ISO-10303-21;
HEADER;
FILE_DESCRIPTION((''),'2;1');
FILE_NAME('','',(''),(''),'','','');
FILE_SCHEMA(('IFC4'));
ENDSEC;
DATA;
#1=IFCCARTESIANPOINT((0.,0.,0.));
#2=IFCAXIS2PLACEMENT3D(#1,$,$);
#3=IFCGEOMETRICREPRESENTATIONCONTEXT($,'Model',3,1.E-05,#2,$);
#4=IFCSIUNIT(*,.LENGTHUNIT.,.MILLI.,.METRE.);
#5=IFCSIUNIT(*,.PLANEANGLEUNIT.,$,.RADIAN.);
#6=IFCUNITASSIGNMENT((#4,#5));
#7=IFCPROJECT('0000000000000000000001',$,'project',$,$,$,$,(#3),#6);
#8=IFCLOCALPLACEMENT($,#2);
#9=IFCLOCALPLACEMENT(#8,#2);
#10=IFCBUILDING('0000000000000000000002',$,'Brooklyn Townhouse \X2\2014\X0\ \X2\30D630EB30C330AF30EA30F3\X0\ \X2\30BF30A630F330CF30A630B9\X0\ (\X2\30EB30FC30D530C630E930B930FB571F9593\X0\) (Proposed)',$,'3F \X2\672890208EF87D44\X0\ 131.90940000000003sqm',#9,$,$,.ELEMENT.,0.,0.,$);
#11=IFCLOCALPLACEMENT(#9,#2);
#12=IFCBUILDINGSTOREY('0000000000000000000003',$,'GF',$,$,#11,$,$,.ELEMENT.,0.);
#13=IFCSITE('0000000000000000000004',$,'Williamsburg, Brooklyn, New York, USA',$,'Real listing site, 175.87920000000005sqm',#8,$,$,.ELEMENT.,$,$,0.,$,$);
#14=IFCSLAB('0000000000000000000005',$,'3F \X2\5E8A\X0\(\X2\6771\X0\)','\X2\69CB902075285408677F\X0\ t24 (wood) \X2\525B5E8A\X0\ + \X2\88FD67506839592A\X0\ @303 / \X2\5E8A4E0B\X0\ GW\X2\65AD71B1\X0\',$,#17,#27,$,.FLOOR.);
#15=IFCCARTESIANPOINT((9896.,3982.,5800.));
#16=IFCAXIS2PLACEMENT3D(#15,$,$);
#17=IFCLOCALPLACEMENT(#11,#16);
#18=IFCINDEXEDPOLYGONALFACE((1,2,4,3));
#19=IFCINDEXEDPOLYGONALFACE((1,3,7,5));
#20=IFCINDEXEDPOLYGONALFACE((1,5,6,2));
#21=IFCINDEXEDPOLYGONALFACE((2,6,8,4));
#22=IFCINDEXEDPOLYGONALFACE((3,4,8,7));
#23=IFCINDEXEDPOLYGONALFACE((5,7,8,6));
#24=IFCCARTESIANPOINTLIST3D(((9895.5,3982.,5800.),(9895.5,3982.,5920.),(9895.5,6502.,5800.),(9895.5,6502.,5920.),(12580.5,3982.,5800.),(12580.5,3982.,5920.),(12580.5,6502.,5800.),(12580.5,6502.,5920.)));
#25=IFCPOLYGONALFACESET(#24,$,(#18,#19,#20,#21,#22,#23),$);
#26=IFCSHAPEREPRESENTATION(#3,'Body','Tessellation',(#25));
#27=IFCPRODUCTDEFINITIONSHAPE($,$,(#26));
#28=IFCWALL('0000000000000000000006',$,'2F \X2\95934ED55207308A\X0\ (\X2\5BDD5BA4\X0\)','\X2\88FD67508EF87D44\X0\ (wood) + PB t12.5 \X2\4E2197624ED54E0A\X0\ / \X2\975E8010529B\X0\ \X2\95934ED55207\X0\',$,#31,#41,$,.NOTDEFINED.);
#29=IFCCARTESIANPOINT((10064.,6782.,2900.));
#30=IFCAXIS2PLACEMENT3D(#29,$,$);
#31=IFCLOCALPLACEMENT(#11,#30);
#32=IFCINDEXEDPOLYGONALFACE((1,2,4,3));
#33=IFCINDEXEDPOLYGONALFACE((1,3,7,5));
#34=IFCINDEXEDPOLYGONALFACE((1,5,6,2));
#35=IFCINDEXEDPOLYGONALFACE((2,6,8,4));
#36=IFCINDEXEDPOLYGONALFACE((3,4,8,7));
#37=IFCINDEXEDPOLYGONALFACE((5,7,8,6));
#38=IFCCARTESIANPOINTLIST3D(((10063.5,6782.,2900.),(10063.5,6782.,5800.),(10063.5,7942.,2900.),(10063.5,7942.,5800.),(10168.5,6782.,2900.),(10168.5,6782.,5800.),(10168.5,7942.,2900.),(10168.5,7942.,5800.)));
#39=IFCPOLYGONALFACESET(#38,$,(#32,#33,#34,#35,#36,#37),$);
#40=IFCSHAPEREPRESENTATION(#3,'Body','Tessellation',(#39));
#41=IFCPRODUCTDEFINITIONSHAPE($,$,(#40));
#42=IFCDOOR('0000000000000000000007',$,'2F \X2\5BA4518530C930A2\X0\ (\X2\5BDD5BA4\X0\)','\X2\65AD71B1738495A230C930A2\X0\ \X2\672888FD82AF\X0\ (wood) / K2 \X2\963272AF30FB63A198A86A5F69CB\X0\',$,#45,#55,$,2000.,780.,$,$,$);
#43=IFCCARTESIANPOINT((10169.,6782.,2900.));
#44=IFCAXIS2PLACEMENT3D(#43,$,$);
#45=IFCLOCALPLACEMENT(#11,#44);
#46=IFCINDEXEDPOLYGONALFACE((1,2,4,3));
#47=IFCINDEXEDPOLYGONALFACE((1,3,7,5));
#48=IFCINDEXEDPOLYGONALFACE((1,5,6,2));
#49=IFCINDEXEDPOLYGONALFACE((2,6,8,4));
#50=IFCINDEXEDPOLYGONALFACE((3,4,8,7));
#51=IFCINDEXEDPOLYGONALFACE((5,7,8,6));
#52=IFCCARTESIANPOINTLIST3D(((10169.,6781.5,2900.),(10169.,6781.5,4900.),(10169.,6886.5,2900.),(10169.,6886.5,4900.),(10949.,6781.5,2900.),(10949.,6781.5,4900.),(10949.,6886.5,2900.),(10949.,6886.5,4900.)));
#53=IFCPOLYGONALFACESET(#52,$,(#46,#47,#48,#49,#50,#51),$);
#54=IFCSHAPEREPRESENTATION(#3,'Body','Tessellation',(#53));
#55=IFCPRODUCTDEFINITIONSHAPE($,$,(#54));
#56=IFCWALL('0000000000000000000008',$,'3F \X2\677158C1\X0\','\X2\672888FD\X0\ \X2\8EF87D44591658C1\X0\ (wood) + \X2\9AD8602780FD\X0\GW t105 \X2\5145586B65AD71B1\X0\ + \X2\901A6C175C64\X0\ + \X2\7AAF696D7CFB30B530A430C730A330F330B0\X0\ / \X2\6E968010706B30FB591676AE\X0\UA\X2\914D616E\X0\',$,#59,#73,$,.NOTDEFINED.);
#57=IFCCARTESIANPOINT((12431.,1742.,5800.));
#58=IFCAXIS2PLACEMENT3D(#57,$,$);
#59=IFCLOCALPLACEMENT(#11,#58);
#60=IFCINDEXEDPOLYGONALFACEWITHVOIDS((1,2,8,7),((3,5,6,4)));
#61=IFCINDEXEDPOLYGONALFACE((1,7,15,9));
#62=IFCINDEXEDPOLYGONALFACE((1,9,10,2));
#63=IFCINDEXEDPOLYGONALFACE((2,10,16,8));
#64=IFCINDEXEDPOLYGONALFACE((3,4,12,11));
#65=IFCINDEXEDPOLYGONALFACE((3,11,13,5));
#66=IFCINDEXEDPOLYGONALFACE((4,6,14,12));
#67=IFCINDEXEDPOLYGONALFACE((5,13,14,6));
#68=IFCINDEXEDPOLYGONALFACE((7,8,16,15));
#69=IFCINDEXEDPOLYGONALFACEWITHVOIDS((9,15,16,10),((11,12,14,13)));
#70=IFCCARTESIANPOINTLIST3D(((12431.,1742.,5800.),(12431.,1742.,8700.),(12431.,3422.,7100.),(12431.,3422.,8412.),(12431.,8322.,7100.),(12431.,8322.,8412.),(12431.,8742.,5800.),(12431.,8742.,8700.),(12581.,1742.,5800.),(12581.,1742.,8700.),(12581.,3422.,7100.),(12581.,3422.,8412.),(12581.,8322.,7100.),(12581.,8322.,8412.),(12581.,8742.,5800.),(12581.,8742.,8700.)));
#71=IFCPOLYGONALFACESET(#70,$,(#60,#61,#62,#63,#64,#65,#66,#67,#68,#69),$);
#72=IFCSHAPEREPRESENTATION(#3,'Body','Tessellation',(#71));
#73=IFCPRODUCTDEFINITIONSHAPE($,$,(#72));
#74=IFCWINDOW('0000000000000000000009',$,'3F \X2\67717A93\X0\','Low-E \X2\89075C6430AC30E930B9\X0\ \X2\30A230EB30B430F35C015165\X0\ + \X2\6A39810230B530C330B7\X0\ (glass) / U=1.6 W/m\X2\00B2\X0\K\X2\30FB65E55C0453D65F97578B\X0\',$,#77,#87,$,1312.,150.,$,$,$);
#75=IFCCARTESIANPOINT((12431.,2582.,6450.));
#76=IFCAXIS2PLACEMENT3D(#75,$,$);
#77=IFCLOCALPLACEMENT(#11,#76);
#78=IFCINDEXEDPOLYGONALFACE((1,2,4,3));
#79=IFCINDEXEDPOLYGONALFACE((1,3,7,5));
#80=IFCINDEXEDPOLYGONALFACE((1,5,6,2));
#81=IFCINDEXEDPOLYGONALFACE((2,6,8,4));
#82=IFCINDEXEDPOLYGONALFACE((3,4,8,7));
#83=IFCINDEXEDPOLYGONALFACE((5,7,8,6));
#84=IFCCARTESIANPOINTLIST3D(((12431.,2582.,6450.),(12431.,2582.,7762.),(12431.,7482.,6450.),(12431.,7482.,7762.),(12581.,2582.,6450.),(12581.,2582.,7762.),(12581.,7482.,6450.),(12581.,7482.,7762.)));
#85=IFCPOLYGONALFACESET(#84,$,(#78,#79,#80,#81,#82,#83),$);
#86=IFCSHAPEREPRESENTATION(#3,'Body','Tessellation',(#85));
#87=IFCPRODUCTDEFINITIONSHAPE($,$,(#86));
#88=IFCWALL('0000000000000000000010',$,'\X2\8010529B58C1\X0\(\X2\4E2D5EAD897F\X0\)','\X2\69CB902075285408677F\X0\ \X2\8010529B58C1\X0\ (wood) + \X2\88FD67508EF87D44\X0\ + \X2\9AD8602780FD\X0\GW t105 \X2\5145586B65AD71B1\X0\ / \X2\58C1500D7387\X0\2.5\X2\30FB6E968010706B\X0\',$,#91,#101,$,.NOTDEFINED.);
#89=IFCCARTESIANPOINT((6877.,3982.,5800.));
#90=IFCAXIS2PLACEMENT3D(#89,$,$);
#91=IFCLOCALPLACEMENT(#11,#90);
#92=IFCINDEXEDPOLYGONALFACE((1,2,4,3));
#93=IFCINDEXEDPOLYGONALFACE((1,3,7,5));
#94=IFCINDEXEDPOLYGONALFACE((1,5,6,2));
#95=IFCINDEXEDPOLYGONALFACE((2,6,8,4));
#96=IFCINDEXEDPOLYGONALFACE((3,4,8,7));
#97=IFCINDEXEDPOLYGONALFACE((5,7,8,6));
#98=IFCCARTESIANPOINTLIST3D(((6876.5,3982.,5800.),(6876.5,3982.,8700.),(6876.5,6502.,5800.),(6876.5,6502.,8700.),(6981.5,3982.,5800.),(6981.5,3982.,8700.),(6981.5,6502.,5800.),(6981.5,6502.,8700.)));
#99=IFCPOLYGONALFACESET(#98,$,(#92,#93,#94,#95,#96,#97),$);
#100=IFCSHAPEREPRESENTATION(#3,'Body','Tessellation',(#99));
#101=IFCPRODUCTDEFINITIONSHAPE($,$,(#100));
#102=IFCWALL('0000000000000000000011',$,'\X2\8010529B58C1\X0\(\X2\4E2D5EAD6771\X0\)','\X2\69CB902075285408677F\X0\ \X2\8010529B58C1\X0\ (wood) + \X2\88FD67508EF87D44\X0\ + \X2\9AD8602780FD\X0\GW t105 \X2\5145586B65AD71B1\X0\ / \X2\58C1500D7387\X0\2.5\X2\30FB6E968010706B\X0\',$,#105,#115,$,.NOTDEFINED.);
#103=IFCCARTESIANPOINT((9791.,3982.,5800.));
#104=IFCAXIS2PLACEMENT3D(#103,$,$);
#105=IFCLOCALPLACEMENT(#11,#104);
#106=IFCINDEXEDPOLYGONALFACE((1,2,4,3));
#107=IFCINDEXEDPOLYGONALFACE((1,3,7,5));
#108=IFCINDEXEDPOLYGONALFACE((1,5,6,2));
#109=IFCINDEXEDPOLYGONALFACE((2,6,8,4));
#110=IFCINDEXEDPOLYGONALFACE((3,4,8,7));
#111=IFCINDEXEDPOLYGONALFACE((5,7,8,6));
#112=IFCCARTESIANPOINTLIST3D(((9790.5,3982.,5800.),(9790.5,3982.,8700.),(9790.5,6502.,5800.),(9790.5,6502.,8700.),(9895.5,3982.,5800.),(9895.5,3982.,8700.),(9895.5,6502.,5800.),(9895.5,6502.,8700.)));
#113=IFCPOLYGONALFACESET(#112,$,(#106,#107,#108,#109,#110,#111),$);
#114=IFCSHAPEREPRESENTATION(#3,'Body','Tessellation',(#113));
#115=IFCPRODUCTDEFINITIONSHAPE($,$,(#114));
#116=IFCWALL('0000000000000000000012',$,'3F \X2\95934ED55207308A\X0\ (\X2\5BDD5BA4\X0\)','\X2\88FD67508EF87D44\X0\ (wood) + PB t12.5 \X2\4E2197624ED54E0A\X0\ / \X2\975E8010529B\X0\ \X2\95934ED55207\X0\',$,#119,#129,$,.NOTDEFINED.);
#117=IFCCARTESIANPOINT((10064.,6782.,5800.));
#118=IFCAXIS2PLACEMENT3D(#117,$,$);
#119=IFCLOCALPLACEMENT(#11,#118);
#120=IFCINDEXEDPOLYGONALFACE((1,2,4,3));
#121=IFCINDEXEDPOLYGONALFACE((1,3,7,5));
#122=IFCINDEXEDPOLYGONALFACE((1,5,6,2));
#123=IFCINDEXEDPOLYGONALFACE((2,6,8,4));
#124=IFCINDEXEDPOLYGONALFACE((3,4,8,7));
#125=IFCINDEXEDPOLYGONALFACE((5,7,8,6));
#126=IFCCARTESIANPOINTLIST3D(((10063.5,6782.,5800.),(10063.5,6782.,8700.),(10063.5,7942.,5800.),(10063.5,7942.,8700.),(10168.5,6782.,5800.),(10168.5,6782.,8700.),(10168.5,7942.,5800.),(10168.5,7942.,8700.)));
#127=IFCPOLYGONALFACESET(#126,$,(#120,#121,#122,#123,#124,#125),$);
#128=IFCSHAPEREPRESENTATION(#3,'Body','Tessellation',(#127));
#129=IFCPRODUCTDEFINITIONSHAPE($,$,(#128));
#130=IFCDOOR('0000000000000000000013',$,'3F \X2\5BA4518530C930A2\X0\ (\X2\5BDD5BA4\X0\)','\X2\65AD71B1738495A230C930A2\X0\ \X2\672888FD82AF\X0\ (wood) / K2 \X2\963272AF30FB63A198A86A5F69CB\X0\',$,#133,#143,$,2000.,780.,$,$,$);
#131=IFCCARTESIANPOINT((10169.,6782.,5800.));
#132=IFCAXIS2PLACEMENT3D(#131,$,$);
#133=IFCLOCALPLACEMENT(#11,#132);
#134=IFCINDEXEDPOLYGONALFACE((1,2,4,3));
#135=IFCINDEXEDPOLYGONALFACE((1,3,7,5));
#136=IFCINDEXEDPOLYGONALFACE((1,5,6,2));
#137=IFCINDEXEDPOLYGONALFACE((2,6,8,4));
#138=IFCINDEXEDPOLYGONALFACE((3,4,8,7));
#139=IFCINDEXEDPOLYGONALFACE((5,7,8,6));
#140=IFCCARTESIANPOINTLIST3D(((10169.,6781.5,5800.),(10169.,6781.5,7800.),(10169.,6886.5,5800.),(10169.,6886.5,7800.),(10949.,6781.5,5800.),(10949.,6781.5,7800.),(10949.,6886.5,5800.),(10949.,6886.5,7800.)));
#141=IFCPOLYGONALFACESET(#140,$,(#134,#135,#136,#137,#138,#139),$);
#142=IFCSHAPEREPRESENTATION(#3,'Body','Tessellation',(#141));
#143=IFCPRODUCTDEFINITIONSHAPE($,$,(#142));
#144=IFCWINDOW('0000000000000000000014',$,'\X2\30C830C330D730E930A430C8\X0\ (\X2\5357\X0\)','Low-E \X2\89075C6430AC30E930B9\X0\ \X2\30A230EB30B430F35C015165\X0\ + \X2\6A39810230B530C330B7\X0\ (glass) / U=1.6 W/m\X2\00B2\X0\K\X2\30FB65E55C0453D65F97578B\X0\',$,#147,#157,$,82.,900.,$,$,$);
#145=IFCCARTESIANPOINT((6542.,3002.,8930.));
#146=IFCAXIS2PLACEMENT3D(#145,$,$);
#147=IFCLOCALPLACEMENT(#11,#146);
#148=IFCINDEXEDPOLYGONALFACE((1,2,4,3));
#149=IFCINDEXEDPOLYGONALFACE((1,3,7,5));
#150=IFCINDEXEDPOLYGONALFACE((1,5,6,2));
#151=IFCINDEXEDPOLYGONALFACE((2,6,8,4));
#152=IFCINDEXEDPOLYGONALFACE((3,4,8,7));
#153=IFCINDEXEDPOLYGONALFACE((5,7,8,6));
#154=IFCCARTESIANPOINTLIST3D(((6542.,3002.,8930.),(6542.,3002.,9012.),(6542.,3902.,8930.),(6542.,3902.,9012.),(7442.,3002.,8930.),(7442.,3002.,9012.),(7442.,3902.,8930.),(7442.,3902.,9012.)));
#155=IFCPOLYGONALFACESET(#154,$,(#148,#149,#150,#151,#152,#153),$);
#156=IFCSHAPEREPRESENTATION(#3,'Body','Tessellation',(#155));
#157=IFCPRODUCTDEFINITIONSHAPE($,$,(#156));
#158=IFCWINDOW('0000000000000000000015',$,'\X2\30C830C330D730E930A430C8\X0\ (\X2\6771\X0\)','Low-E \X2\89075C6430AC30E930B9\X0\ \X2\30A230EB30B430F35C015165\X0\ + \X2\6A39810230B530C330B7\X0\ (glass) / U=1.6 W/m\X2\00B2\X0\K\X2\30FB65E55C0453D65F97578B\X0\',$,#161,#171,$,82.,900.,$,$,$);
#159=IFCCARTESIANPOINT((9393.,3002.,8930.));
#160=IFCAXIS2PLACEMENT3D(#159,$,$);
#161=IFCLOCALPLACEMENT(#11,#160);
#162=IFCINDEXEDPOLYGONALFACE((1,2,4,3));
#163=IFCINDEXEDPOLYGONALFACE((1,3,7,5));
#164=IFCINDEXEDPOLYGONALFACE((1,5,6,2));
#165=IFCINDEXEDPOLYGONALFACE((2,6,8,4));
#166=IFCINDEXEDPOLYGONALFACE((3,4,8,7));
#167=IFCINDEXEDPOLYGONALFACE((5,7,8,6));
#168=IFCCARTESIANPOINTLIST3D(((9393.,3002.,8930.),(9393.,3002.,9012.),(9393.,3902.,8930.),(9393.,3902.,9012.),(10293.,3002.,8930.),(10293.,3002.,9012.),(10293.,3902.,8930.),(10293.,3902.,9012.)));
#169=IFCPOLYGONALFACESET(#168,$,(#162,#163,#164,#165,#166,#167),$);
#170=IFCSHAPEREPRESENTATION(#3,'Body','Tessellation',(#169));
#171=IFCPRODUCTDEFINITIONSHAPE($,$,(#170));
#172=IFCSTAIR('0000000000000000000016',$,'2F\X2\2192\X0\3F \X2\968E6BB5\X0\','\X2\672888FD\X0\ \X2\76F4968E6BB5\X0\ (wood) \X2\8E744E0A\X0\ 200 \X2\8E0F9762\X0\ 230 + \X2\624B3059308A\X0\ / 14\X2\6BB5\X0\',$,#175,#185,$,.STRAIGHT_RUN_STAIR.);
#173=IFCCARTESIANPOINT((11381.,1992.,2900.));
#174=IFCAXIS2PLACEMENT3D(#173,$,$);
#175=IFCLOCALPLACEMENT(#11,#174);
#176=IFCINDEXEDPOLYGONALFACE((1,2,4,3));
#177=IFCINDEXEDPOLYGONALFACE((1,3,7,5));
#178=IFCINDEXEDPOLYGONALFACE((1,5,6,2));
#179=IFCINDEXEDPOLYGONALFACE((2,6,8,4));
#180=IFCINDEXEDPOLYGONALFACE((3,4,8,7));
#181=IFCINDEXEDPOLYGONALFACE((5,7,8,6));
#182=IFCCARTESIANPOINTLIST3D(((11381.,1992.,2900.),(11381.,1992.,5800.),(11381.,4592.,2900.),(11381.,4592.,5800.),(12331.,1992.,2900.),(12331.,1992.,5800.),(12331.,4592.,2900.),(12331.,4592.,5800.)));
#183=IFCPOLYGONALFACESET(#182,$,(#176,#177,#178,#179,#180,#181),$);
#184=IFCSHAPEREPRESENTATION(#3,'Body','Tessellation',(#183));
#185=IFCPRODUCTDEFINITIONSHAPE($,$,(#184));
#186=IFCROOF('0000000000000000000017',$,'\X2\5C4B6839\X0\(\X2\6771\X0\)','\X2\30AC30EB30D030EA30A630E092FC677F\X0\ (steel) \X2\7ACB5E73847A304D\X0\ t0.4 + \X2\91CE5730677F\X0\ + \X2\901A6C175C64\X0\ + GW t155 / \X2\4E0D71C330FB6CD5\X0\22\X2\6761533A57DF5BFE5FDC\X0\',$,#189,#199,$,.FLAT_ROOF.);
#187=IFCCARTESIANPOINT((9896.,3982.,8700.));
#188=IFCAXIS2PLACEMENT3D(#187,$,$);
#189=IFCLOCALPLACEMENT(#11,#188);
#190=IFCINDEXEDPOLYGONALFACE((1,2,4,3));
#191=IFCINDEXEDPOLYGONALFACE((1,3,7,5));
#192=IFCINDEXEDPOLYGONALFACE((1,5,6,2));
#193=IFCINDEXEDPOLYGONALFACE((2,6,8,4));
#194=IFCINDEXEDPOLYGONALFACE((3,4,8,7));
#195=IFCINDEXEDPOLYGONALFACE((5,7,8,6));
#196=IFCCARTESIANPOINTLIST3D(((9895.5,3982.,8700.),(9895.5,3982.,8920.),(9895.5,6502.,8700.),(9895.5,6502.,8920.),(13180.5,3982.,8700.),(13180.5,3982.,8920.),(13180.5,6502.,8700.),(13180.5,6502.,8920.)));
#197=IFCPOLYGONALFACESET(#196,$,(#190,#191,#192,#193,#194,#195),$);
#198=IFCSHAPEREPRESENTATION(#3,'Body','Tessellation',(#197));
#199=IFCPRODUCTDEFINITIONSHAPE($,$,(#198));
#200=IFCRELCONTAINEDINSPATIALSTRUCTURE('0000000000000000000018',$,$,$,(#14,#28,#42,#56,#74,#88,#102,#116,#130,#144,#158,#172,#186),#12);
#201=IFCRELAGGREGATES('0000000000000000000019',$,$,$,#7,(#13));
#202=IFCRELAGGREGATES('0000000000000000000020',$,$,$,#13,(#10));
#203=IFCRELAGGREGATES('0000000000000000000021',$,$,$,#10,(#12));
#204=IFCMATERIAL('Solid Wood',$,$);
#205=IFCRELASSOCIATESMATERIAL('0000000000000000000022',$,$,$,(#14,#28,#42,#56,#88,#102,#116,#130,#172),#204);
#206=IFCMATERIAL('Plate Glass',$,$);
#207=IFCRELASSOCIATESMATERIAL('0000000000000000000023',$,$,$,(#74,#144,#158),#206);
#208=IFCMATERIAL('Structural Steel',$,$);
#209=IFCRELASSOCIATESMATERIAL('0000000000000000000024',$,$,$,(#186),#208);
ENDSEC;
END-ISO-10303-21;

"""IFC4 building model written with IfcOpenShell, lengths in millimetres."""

from ifc_helpers import new_model, si_unit, frame, frame_2d, origin, place, context, project, spatial, rectangle, extrude, material, element, fill, save


model = new_model("IFC4")

# Units and contexts
model_context = context("Model", 3, precision=1e-05, world=origin())
ifc_project = project(units=[si_unit("LENGTHUNIT", "METRE", prefix="MILLI"), si_unit("PLANEANGLEUNIT", "RADIAN")], contexts=[model_context])

# Site, building, storey
site_placement = place(None, origin())
site = spatial("IfcSite", under=ifc_project, at=site_placement, Name="Williamsburg, Brooklyn, New York, USA", ObjectType="Real listing site, 175.87920000000005sqm", CompositionType="ELEMENT", RefElevation=0.0)
building_placement = place(site_placement, origin())
building = spatial("IfcBuilding", under=site, at=building_placement, Name="Brooklyn Townhouse — ブルックリン タウンハウス (ルーフテラス・土間) (Proposed)", ObjectType="3F 木造軸組 131.90940000000003sqm", CompositionType="ELEMENT", ElevationOfRefHeight=0.0, ElevationOfTerrain=0.0)
storey_placement = place(building_placement, origin())
storey = spatial("IfcBuildingStorey", under=building, at=storey_placement, Name="GF", CompositionType="ELEMENT", Elevation=0.0)

# Slab
ifc_material_1 = material(Name="Solid Wood")
slab_placement = place(storey_placement, frame((9896.0, 3982.0, 5800.0)))
element("IfcSlab", 1, at=slab_placement, inside=storey, material=ifc_material_1, Name="3F 床(東)", Description="構造用合板 t24 (wood) 剛床 + 製材根太 @303 / 床下 GW断熱", PredefinedType="FLOOR", context=model_context, shape_type="SweptSolid", body=[
    extrude(rectangle(XDim=2685.0, YDim=2520.0, at=frame_2d((1342.0, 1260.0))), frame((9896.0, 3982.0, 5800.0)), (0.0, 0.0, 1.0), 120.0),
])

# Wall
wall_1_placement = place(storey_placement, frame((10064.0, 6782.0, 2900.0)))
element("IfcWall", 2, at=wall_1_placement, inside=storey, material=ifc_material_1, Name="2F 間仕切り (寝室)", Description="製材軸組 (wood) + PB t12.5 両面仕上 / 非耐力 間仕切", PredefinedType="NOTDEFINED", context=model_context, shape_type="SweptSolid", body=[
    extrude(rectangle(XDim=105.0, YDim=1160.0, at=frame_2d((52.0, 580.0))), frame((10064.0, 6782.0, 2900.0)), (0.0, 0.0, 1.0), 2900.0),
])

# Door
door_1_placement = place(storey_placement, frame((10169.0, 6782.0, 2900.0)))
element("IfcDoor", 3, at=door_1_placement, inside=storey, material=ifc_material_1, Name="2F 室内ドア (寝室)", Description="断熱玄関ドア 木製芯 (wood) / K2 防犯・採風機構", OverallHeight=2000.0, OverallWidth=780.0, context=model_context, shape_type="SweptSolid", body=[
    extrude(rectangle(XDim=780.0, YDim=105.0, at=frame_2d((390.0, 52.0))), frame((10169.0, 6782.0, 2900.0)), (0.0, 0.0, 1.0), 2000.0),
])

# Wall, opening, window
wall_2_placement = place(storey_placement, frame((12431.0, 1742.0, 5800.0)))
wall_2 = element("IfcWall", 4, at=wall_2_placement, inside=storey, material=ifc_material_1, Name="3F 東壁", Description="木製 軸組外壁 (wood) + 高性能GW t105 充填断熱 + 通気層 + 窯業系サイディング / 準耐火・外皮UA配慮", PredefinedType="NOTDEFINED", context=model_context, shape_type="SweptSolid", body=[
    extrude(rectangle(XDim=150.0, YDim=7000.0, at=frame_2d((75.0, 3500.0))), frame((12431.0, 1742.0, 5800.0)), (0.0, 0.0, 1.0), 2900.0),
])
opening_1_placement = place(storey_placement, frame((12431.0, 2582.0, 6450.0)))
opening_1 = element("IfcOpeningElement", 5, at=opening_1_placement, cuts=wall_2, PredefinedType="NOTDEFINED", context=model_context, shape_type="SweptSolid", body=[
    extrude(rectangle(XDim=150.0, YDim=4900.0, at=frame_2d((75.0, 2450.0))), frame((12431.0, 2582.0, 6450.0)), (0.0, 0.0, 1.0), 1312.0),
])
ifc_material_2 = material(Name="Plate Glass")
window_1_placement = place(storey_placement, frame((12431.0, 2582.0, 6450.0)))
window_1 = element("IfcWindow", 6, at=window_1_placement, inside=storey, material=ifc_material_2, Name="3F 東窓", Description="Low-E 複層ガラス アルゴン封入 + 樹脂サッシ (glass) / U=1.6 W/m²K・日射取得型", OverallHeight=1312.0, OverallWidth=150.0, context=model_context, shape_type="SweptSolid", body=[
    extrude(rectangle(XDim=150.0, YDim=4900.0, at=frame_2d((75.0, 2450.0))), frame((12431.0, 2582.0, 6450.0)), (0.0, 0.0, 1.0), 1312.0),
])
fill(opening_1, window_1)

# Walls
wall_3_placement = place(storey_placement, frame((6877.0, 3982.0, 5800.0)))
element("IfcWall", 7, at=wall_3_placement, inside=storey, material=ifc_material_1, Name="耐力壁(中庭西)", Description="構造用合板 耐力壁 (wood) + 製材軸組 + 高性能GW t105 充填断熱 / 壁倍率2.5・準耐火", PredefinedType="NOTDEFINED", context=model_context, shape_type="SweptSolid", body=[
    extrude(rectangle(XDim=105.0, YDim=2520.0, at=frame_2d((52.0, 1260.0))), frame((6877.0, 3982.0, 5800.0)), (0.0, 0.0, 1.0), 2900.0),
])
wall_4_placement = place(storey_placement, frame((9791.0, 3982.0, 5800.0)))
element("IfcWall", 8, at=wall_4_placement, inside=storey, material=ifc_material_1, Name="耐力壁(中庭東)", Description="構造用合板 耐力壁 (wood) + 製材軸組 + 高性能GW t105 充填断熱 / 壁倍率2.5・準耐火", PredefinedType="NOTDEFINED", context=model_context, shape_type="SweptSolid", body=[
    extrude(rectangle(XDim=105.0, YDim=2520.0, at=frame_2d((52.0, 1260.0))), frame((9791.0, 3982.0, 5800.0)), (0.0, 0.0, 1.0), 2900.0),
])
wall_5_placement = place(storey_placement, frame((10064.0, 6782.0, 5800.0)))
element("IfcWall", 9, at=wall_5_placement, inside=storey, material=ifc_material_1, Name="3F 間仕切り (寝室)", Description="製材軸組 (wood) + PB t12.5 両面仕上 / 非耐力 間仕切", PredefinedType="NOTDEFINED", context=model_context, shape_type="SweptSolid", body=[
    extrude(rectangle(XDim=105.0, YDim=1160.0, at=frame_2d((52.0, 580.0))), frame((10064.0, 6782.0, 5800.0)), (0.0, 0.0, 1.0), 2900.0),
])

# Door
door_2_placement = place(storey_placement, frame((10169.0, 6782.0, 5800.0)))
element("IfcDoor", 10, at=door_2_placement, inside=storey, material=ifc_material_1, Name="3F 室内ドア (寝室)", Description="断熱玄関ドア 木製芯 (wood) / K2 防犯・採風機構", OverallHeight=2000.0, OverallWidth=780.0, context=model_context, shape_type="SweptSolid", body=[
    extrude(rectangle(XDim=780.0, YDim=105.0, at=frame_2d((390.0, 52.0))), frame((10169.0, 6782.0, 5800.0)), (0.0, 0.0, 1.0), 2000.0),
])

# Windows
window_2_placement = place(storey_placement, frame((6542.0, 3002.0, 8930.0)))
element("IfcWindow", 11, at=window_2_placement, inside=storey, material=ifc_material_2, Name="トップライト (南)", Description="Low-E 複層ガラス アルゴン封入 + 樹脂サッシ (glass) / U=1.6 W/m²K・日射取得型", OverallHeight=82.0, OverallWidth=900.0, context=model_context, shape_type="SweptSolid", body=[
    extrude(rectangle(XDim=900.0, YDim=900.0, at=frame_2d((450.0, 450.0))), frame((6542.0, 3002.0, 8930.0)), (0.0, 0.0, 1.0), 82.0),
])
window_3_placement = place(storey_placement, frame((9393.0, 3002.0, 8930.0)))
element("IfcWindow", 12, at=window_3_placement, inside=storey, material=ifc_material_2, Name="トップライト (東)", Description="Low-E 複層ガラス アルゴン封入 + 樹脂サッシ (glass) / U=1.6 W/m²K・日射取得型", OverallHeight=82.0, OverallWidth=900.0, context=model_context, shape_type="SweptSolid", body=[
    extrude(rectangle(XDim=900.0, YDim=900.0, at=frame_2d((450.0, 450.0))), frame((9393.0, 3002.0, 8930.0)), (0.0, 0.0, 1.0), 82.0),
])

# Stair
stair_placement = place(storey_placement, frame((11381.0, 1992.0, 2900.0)))
element("IfcStair", 13, at=stair_placement, inside=storey, material=ifc_material_1, Name="2F→3F 階段", Description="木製 直階段 (wood) 蹴上 200 踏面 230 + 手すり / 14段", PredefinedType="STRAIGHT_RUN_STAIR", context=model_context, shape_type="SweptSolid", body=[
    extrude(rectangle(XDim=950.0, YDim=2600.0, at=frame_2d((475.0, 1300.0))), frame((11381.0, 1992.0, 2900.0)), (0.0, 0.0, 1.0), 2900.0),
])

# Roof
ifc_material_3 = material(Name="Structural Steel")
for number, where, name in (
    (14, (9896.0, 3982.0, 8700.0), "屋根(東)"),
):
    element("IfcRoof", number, at=place(storey_placement, frame(where)), inside=storey, material=ifc_material_3, Name=name, Description="ガルバリウム鋼板 (steel) 立平葺き t0.4 + 野地板 + 通気層 + GW t155 / 不燃・法22条区域対応", PredefinedType="FLAT_ROOF", context=model_context, shape_type="SweptSolid", body=[
        extrude(rectangle(XDim=3285.0, YDim=2520.0, at=frame_2d((1642.0, 1260.0))), frame((9896.0, 3982.0, 8700.0)), (0.0, 0.0, 1.0), 220.0),
    ])

save(model, "model.ifc")
